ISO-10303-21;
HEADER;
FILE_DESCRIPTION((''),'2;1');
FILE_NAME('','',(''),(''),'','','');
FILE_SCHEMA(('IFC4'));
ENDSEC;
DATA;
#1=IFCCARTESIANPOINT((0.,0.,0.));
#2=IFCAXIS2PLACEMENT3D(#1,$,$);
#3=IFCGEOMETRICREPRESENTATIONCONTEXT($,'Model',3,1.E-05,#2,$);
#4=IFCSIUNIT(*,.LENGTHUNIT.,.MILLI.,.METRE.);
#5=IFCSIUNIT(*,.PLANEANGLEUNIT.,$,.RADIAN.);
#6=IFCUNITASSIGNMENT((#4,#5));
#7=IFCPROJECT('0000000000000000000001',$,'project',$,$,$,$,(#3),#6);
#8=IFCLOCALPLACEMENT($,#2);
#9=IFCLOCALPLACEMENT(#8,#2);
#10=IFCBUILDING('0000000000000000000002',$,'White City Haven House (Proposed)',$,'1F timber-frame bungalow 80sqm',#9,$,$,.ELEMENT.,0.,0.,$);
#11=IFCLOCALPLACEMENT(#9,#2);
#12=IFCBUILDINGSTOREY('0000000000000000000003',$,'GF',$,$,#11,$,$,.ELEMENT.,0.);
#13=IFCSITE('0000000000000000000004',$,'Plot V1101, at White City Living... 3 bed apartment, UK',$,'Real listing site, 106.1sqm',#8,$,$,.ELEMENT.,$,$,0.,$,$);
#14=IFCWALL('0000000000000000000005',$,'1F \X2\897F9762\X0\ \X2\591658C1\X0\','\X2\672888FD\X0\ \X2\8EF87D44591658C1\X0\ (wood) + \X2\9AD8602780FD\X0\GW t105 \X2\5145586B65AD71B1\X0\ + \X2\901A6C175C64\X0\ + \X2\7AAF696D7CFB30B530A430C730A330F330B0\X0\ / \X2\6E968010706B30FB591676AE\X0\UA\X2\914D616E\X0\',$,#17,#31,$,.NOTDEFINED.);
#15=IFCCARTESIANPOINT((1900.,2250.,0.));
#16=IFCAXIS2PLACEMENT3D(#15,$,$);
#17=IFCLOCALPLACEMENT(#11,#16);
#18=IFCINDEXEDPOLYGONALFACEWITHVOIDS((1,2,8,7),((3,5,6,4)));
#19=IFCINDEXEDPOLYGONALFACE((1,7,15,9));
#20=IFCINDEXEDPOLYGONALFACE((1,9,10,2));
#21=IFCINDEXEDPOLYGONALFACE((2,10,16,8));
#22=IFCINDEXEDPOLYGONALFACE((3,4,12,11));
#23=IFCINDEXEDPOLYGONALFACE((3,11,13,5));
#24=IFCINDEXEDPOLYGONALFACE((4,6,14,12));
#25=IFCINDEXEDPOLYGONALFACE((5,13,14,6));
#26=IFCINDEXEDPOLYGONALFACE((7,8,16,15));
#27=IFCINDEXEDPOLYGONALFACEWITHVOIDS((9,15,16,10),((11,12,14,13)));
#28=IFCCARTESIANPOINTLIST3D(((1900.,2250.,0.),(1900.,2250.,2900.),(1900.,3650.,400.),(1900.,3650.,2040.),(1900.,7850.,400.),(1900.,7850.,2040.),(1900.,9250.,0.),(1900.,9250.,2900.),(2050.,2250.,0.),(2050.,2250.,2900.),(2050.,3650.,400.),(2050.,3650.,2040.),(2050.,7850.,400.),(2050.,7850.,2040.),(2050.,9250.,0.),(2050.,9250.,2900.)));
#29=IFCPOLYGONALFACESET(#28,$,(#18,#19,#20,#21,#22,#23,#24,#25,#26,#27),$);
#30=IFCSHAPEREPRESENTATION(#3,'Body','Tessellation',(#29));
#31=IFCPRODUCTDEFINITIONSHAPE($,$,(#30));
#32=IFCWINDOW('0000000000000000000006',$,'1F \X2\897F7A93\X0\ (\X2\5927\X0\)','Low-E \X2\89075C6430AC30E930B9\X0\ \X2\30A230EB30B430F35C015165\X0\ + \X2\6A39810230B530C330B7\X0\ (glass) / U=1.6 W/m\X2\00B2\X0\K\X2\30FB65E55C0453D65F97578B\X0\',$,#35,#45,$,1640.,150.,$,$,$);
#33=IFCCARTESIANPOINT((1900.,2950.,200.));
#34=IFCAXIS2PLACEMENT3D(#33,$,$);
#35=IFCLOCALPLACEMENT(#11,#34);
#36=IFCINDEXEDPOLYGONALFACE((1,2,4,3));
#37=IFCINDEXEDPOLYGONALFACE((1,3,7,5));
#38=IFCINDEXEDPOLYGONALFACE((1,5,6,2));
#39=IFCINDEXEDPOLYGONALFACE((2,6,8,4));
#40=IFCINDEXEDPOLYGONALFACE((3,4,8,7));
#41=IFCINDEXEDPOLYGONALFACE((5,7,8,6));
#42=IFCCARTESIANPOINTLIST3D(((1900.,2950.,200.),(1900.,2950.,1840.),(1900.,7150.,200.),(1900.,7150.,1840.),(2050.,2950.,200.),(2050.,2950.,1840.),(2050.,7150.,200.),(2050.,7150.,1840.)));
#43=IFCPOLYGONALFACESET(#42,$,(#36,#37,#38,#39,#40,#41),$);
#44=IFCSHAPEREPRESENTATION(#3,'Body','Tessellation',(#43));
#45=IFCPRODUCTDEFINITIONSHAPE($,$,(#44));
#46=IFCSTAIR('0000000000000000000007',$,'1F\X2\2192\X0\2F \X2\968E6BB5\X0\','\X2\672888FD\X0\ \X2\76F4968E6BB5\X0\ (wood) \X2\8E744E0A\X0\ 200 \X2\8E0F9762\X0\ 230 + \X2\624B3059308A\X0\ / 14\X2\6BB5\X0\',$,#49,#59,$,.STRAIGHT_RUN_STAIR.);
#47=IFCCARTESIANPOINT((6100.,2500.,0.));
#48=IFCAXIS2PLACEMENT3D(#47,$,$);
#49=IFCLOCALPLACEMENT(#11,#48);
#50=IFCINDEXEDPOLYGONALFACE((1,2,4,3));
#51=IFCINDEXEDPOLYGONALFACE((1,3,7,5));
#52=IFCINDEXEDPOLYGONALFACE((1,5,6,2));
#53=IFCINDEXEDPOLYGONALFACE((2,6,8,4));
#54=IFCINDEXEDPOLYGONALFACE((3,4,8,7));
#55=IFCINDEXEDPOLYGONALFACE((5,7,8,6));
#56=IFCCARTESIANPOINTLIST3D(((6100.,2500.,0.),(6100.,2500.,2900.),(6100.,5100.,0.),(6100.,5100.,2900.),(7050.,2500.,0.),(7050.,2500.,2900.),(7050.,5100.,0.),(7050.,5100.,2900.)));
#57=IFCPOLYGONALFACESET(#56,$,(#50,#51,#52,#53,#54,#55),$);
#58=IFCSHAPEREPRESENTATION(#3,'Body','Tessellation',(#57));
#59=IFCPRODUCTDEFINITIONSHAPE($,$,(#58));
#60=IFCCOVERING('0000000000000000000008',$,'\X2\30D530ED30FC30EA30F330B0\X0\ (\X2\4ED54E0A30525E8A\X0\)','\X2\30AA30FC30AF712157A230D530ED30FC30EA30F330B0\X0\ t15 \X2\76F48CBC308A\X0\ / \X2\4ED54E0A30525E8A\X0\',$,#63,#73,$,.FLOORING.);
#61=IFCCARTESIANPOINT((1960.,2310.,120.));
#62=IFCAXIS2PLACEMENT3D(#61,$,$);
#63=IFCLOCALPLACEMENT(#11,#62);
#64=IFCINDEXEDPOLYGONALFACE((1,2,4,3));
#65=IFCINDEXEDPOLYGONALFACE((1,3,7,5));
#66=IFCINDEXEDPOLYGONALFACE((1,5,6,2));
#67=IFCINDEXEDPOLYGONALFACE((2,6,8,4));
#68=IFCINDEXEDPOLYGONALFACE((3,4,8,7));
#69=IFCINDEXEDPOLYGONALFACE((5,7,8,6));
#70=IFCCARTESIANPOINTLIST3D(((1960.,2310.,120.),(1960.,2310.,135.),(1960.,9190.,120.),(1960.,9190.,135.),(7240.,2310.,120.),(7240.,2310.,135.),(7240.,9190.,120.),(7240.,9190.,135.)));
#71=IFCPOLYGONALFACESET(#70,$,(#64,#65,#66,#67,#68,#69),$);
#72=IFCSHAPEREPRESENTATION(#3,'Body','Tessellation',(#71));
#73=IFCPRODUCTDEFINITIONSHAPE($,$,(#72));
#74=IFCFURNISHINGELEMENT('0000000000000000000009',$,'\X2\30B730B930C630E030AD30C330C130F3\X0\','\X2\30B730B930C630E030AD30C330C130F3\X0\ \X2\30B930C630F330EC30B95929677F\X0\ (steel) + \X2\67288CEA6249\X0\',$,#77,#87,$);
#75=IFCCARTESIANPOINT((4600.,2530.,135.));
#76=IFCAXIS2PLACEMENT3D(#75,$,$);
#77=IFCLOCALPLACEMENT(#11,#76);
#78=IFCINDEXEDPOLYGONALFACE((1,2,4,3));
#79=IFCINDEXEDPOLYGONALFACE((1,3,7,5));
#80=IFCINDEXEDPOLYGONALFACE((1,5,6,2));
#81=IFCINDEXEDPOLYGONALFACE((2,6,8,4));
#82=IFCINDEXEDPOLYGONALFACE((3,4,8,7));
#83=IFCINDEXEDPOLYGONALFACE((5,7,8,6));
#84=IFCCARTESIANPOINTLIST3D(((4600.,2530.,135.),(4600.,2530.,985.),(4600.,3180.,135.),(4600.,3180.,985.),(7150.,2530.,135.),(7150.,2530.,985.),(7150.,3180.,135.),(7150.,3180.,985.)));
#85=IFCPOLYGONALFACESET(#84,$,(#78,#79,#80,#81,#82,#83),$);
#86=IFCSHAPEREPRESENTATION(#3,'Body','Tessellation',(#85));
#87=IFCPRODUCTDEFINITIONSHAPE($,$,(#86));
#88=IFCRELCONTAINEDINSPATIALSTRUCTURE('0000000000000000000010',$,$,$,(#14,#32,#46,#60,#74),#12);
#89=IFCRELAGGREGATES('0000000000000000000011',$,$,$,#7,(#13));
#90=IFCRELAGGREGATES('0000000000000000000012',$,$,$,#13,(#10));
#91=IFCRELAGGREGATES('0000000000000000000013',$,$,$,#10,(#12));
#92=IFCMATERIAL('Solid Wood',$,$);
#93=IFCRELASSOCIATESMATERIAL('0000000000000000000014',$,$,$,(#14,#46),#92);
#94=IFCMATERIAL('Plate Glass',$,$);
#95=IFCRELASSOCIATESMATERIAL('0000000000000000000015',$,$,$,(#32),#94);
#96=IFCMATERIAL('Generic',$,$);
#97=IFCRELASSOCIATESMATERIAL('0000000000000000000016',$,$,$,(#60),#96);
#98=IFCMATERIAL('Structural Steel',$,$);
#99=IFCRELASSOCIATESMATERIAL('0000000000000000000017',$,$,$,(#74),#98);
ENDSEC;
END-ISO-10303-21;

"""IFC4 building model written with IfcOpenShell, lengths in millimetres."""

from ifc_helpers import new_model, si_unit, frame, frame_2d, origin, place, context, project, spatial, rectangle, extrude, material, element, fill, save


model = new_model("IFC4")

# Units and contexts
model_context = context("Model", 3, precision=1e-05, world=origin())
ifc_project = project(units=[si_unit("LENGTHUNIT", "METRE", prefix="MILLI"), si_unit("PLANEANGLEUNIT", "RADIAN")], contexts=[model_context])

# Site, building, storey
site_placement = place(None, origin())
site = spatial("IfcSite", under=ifc_project, at=site_placement, Name="Plot V1101, at White City Living... 3 bed apartment, UK", ObjectType="Real listing site, 106.1sqm", CompositionType="ELEMENT", RefElevation=0.0)
building_placement = place(site_placement, origin())
building = spatial("IfcBuilding", under=site, at=building_placement, Name="White City Haven House (Proposed)", ObjectType="1F timber-frame bungalow 80sqm", CompositionType="ELEMENT", ElevationOfRefHeight=0.0, ElevationOfTerrain=0.0)
storey_placement = place(building_placement, origin())
storey = spatial("IfcBuildingStorey", under=building, at=storey_placement, Name="GF", CompositionType="ELEMENT", Elevation=0.0)

# Shared definitions
ifc_material_1 = material(Name="Solid Wood")
ifc_material_2 = material(Name="Generic")

# Shared definitions
ifc_material_3 = material(Name="Plate Glass")

# Wall, opening, window
wall_1_placement = place(storey_placement, frame((1900.0, 2250.0, 0.0)))
wall_1 = element("IfcWall", 1, at=wall_1_placement, inside=storey, material=ifc_material_1, Name="1F 西面 外壁", Description="木製 軸組外壁 (wood) + 高性能GW t105 充填断熱 + 通気層 + 窯業系サイディング / 準耐火・外皮UA配慮", PredefinedType="NOTDEFINED", context=model_context, shape_type="SweptSolid", body=[
    extrude(rectangle(XDim=150.0, YDim=7000.0, at=frame_2d((75.0, 3500.0))), frame((1900.0, 2250.0, 0.0)), (0.0, 0.0, 1.0), 2900.0),
])
opening_1_placement = place(storey_placement, frame((1900.0, 2950.0, 200.0)))
opening_1 = element("IfcOpeningElement", 2, at=opening_1_placement, cuts=wall_1, PredefinedType="NOTDEFINED", context=model_context, shape_type="SweptSolid", body=[
    extrude(rectangle(XDim=150.0, YDim=4200.0, at=frame_2d((75.0, 2100.0))), frame((1900.0, 2950.0, 200.0)), (0.0, 0.0, 1.0), 1640.0),
])
window_1_placement = place(storey_placement, frame((1900.0, 2950.0, 200.0)))
window_1 = element("IfcWindow", 3, at=window_1_placement, inside=storey, material=ifc_material_3, Name="1F 西窓 (大)", Description="Low-E 複層ガラス アルゴン封入 + 樹脂サッシ (glass) / U=1.6 W/m²K・日射取得型", OverallHeight=1640.0, OverallWidth=150.0, context=model_context, shape_type="SweptSolid", body=[
    extrude(rectangle(XDim=150.0, YDim=4200.0, at=frame_2d((75.0, 2100.0))), frame((1900.0, 2950.0, 200.0)), (0.0, 0.0, 1.0), 1640.0),
])
fill(opening_1, window_1)

# Stair
stair_placement = place(storey_placement, frame((6100.0, 2500.0, 0.0)))
element("IfcStair", 4, at=stair_placement, inside=storey, material=ifc_material_1, Name="1F→2F 階段", Description="木製 直階段 (wood) 蹴上 200 踏面 230 + 手すり / 14段", PredefinedType="STRAIGHT_RUN_STAIR", context=model_context, shape_type="SweptSolid", body=[
    extrude(rectangle(XDim=950.0, YDim=2600.0, at=frame_2d((475.0, 1300.0))), frame((6100.0, 2500.0, 0.0)), (0.0, 0.0, 1.0), 2900.0),
])

# Covering
covering_placement = place(storey_placement, frame((1960.0, 2310.0, 120.0)))
element("IfcCovering", 5, at=covering_placement, inside=storey, material=ifc_material_2, Name="フローリング (仕上げ床)", Description="オーク無垢フローリング t15 直貼り / 仕上げ床", PredefinedType="FLOORING", context=model_context, shape_type="SweptSolid", body=[
    extrude(rectangle(XDim=5280.0, YDim=6880.0, at=frame_2d((2640.0, 3440.0))), frame((1960.0, 2310.0, 120.0)), (0.0, 0.0, 1.0), 15.0),
])

# Furnishing element
ifc_material_4 = material(Name="Structural Steel")
furnishing_placement = place(storey_placement, frame((4600.0, 2530.0, 135.0)))
element("IfcFurnishingElement", 6, at=furnishing_placement, inside=storey, material=ifc_material_4, Name="システムキッチン", Description="システムキッチン ステンレス天板 (steel) + 木質扉", context=model_context, shape_type="SweptSolid", body=[
    extrude(rectangle(XDim=2550.0, YDim=650.0, at=frame_2d((1275.0, 325.0))), frame((4600.0, 2530.0, 135.0)), (0.0, 0.0, 1.0), 850.0),
])

save(model, "model.ifc")
